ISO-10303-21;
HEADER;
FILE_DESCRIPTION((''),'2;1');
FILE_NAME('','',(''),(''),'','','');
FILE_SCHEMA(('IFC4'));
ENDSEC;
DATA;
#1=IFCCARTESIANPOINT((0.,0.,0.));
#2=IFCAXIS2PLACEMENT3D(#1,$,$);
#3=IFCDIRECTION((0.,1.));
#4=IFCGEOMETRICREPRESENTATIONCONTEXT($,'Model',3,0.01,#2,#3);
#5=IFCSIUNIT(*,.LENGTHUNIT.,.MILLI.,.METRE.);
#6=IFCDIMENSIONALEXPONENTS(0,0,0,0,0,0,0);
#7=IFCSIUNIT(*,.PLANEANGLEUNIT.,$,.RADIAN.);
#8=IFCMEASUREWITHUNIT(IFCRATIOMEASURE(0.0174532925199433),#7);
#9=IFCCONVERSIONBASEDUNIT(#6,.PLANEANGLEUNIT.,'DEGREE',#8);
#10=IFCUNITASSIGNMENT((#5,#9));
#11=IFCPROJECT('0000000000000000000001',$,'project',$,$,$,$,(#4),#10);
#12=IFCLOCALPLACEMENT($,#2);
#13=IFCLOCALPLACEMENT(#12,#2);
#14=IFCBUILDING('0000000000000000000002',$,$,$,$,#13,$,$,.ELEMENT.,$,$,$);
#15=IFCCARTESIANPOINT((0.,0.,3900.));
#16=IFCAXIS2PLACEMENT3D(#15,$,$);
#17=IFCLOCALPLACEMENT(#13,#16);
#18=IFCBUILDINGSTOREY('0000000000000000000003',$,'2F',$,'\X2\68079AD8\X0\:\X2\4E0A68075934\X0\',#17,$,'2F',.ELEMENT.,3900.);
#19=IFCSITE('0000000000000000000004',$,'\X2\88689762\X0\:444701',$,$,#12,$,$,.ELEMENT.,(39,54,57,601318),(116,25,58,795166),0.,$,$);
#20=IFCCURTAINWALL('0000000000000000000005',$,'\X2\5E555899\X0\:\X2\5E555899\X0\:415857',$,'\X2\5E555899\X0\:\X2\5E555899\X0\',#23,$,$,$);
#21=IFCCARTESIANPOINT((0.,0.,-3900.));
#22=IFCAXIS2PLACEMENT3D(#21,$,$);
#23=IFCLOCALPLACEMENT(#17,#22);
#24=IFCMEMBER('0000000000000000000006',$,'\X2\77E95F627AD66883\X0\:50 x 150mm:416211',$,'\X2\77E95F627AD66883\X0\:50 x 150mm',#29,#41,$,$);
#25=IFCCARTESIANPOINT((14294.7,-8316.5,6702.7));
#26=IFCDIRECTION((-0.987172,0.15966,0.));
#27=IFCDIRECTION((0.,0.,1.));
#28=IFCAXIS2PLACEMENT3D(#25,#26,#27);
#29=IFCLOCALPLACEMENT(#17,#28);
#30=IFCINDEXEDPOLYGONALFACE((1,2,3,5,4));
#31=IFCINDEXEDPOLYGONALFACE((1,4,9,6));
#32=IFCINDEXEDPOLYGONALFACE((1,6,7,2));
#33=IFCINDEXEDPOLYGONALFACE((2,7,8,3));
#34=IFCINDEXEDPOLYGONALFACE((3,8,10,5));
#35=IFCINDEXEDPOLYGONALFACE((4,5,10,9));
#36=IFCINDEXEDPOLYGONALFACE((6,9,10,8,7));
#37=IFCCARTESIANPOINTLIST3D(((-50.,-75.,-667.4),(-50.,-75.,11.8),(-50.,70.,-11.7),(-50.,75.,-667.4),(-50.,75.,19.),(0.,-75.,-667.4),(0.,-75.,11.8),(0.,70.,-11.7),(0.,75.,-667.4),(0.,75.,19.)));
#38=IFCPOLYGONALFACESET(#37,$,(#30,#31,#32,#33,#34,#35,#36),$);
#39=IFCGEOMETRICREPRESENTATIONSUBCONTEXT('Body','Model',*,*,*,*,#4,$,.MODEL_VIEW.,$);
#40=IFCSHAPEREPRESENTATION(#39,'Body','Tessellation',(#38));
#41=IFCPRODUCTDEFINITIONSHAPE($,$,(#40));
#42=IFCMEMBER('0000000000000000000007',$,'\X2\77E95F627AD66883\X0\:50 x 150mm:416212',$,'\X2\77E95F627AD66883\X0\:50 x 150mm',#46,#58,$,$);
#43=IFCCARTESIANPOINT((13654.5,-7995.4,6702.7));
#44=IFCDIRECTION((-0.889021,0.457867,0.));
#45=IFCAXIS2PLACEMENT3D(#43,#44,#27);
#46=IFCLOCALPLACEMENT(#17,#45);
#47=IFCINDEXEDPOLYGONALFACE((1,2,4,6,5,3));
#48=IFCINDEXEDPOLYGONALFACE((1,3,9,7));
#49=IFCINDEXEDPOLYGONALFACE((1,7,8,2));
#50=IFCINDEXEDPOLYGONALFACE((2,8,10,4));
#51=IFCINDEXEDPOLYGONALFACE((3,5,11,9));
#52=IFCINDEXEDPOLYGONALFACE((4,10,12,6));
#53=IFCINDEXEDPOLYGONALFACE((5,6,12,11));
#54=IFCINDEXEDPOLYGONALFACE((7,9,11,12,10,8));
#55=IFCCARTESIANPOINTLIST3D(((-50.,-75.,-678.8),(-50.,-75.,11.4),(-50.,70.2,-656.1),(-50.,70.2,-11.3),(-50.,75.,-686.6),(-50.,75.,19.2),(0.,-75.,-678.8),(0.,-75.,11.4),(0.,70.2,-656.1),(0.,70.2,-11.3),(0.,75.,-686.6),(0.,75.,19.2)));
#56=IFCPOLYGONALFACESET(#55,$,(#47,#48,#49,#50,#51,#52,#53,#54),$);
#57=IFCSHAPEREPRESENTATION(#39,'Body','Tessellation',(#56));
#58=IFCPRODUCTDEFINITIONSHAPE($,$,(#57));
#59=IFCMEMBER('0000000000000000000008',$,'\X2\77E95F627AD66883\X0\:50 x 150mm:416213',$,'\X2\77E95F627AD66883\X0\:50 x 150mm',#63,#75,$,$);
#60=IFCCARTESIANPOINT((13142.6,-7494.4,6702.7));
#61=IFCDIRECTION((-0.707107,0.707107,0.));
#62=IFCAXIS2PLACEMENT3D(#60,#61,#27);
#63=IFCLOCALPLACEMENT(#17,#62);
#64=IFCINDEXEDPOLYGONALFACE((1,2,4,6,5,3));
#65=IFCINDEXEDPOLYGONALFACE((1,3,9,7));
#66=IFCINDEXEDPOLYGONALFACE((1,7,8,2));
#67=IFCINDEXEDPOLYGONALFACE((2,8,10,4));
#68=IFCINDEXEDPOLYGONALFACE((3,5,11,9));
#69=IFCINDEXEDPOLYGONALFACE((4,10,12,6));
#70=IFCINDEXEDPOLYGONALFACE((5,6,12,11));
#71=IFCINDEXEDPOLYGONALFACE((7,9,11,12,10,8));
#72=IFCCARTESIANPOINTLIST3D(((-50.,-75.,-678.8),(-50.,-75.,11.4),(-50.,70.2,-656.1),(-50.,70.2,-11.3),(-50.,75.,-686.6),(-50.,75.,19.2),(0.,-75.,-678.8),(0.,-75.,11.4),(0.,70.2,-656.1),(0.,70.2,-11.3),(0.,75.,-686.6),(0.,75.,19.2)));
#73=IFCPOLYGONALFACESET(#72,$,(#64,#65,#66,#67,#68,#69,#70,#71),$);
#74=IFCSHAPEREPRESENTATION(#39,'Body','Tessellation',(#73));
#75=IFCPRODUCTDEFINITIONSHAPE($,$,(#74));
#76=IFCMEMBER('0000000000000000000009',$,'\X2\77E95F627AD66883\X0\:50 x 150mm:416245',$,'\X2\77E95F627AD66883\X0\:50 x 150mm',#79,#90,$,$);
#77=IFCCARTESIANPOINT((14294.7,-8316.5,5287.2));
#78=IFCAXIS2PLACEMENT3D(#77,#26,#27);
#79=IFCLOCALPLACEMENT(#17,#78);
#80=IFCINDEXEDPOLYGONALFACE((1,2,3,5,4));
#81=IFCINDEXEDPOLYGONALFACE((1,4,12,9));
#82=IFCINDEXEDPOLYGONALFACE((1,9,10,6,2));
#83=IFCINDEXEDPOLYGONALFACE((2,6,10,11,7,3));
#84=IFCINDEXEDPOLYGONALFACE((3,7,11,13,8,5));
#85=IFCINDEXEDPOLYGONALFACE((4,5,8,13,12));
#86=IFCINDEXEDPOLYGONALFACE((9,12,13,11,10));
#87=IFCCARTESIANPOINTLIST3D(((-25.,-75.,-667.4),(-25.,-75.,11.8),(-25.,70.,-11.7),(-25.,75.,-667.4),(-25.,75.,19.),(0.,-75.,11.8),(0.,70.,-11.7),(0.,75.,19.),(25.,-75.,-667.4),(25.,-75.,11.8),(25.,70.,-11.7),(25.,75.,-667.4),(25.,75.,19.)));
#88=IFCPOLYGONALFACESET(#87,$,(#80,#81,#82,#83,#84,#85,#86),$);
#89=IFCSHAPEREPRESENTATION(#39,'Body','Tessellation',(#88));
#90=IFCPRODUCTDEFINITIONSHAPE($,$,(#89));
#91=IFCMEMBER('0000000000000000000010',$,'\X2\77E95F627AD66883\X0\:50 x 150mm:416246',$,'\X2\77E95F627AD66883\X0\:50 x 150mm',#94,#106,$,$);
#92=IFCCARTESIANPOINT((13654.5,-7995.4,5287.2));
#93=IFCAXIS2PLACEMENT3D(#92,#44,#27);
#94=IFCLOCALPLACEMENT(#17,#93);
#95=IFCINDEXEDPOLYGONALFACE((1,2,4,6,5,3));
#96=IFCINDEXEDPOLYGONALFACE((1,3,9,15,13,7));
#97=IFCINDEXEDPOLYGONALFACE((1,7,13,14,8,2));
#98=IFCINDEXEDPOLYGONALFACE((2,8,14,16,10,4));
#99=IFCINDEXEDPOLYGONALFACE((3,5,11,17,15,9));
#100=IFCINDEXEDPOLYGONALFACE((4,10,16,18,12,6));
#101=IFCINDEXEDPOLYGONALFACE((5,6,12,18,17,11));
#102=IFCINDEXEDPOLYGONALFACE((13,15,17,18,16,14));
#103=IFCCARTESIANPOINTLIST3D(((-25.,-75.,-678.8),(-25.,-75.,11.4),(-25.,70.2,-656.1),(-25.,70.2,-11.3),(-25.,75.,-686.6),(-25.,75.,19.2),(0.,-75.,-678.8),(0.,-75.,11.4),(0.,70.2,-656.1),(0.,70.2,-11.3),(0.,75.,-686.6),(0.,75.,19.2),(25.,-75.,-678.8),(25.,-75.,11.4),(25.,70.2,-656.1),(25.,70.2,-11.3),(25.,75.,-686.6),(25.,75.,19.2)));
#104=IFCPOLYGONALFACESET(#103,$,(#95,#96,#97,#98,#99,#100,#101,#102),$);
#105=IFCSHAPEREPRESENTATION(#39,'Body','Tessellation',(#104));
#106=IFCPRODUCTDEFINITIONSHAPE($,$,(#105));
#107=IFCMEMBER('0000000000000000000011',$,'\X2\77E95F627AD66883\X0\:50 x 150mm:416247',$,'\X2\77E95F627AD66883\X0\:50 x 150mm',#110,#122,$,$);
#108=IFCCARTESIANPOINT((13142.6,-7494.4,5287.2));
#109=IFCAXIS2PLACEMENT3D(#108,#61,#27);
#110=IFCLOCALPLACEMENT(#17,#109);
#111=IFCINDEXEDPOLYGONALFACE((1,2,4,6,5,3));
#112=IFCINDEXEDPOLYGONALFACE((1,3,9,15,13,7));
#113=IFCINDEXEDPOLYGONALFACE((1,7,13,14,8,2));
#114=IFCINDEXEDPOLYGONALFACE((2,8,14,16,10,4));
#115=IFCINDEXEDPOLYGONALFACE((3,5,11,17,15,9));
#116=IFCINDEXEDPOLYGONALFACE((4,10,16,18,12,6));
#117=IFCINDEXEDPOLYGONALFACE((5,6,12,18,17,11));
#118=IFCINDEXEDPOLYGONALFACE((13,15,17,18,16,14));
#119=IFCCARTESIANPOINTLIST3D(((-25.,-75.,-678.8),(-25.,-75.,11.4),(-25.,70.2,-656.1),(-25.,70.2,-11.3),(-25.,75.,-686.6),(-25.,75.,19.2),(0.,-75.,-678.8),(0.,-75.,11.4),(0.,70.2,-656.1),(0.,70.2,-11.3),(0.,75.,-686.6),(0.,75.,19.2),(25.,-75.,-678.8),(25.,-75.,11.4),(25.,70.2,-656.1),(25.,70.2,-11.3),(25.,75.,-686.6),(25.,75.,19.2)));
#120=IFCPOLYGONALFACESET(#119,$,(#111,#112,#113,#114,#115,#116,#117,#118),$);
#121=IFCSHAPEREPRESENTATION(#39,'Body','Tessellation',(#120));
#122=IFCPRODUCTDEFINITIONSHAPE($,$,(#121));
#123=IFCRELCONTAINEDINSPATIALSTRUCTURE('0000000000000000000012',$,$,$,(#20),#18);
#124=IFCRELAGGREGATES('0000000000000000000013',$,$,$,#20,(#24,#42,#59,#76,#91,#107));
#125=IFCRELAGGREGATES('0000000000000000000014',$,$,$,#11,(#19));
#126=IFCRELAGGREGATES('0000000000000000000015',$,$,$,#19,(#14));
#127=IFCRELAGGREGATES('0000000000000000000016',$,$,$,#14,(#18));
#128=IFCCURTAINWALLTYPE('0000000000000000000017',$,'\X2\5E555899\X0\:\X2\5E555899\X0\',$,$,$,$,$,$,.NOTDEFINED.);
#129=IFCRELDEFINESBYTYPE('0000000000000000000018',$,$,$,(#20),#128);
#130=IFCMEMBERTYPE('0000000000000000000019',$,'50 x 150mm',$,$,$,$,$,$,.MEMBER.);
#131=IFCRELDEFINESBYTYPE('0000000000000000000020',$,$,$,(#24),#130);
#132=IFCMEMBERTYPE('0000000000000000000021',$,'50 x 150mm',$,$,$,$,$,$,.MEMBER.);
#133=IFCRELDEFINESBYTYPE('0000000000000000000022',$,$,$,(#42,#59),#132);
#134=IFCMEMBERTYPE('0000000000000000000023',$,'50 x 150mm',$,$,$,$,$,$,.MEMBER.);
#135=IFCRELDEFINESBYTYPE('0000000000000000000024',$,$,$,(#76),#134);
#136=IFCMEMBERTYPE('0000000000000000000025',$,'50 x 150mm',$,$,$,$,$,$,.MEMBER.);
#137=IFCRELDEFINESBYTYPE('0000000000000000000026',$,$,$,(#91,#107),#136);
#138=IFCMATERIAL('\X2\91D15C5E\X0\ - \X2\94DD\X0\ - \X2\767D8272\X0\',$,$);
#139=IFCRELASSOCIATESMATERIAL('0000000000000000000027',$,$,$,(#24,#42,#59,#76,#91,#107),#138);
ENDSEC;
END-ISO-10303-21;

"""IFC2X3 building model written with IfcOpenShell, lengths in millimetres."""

from ifc_helpers import new_model, entity, si_unit, converted_unit, direction, frame, origin, origin_2d_with_axis, place, context, subcontext, project, spatial, polyline, rectangle, extrude, clip, bounded_halfspace, source, transform, mapped, material, type_object, type_shapes, element, aggregate, save


model = new_model("IFC2X3")

# Units and contexts
model_context = context("Model", 3, precision=0.01, world=origin(), true_north=direction((0.0, 1.0)))
body_context = subcontext(model_context, "Body", "Model", "MODEL_VIEW")
ifc_project = project(units=[si_unit("LENGTHUNIT", "METRE", prefix="MILLI"), converted_unit("PLANEANGLEUNIT", "DEGREE", entity("IfcRatioMeasure", 0.0174532925199433), si_unit("PLANEANGLEUNIT", "RADIAN"), dimensions=[0, 0, 0, 0, 0, 0, 0])], contexts=[model_context])

# Site, building, storey
site_placement = place(None, origin())
site = spatial("IfcSite", under=ifc_project, at=site_placement, Name="表面:444701", CompositionType="ELEMENT", RefLatitude=(39, 54, 57, 601318), RefLongitude=(116, 25, 58, 795166), RefElevation=0.0)
building_placement = place(site_placement, origin())
building = spatial("IfcBuilding", under=site, at=building_placement, CompositionType="ELEMENT")
storey_placement = place(building_placement, frame((0.0, 0.0, 3900.0)))
storey = spatial("IfcBuildingStorey", under=building, at=storey_placement, Name="2F", ObjectType="标高:上标头", LongName="2F", CompositionType="ELEMENT", Elevation=3900.0)

# Curtain wall, member
curtain_wall_type = type_object("IfcCurtainWallType", Name="幕墙:幕墙", PredefinedType="NOTDEFINED")
curtain_wall_1_placement = place(storey_placement, frame((0.0, 0.0, -3900.0)))
curtain_wall_1 = element("IfcCurtainWall", 1, at=curtain_wall_1_placement, inside=storey, type_object=curtain_wall_type, Name="幕墙:幕墙:415857", ObjectType="幕墙:幕墙")
ifc_material_1 = material(Name="金属 - 铝 - 白色")
member_type_1 = type_object("IfcMemberType", Name="50 x 150mm", PredefinedType="MEMBER")
shared_shape_1 = source(origin(), body_context, "Body", "Clipping", [
    clip(clip(extrude(rectangle(XDim=50.0, YDim=150.0, at=origin_2d_with_axis()), frame((-25.0, 0.0, -667.4)), (0.0, 0.0, 1.0), 686.4), bounded_halfspace(frame((-1415.5, 78.0, 37.7), z_axis=(0.0, -0.987172, 0.15966), x_axis=(1.0, 0.0, 0.0)), False, frame((-25.0, 0.0, -667.4)), polyline([(25.0, 75.0), (-25.0, 75.0), (-25.0, 70.0), (25.0, 70.0), (25.0, 75.0)]))), bounded_halfspace(frame((-1415.5, 70.0, -11.7), z_axis=(0.0, 0.15966, 0.987172), x_axis=(1.0, 0.0, 0.0)), False, frame((-25.0, 0.0, -667.4)), polyline([(-25.0, 70.0), (-25.0, -75.0), (25.0, -75.0), (25.0, 70.0), (-25.0, 70.0)]))),
])
type_shapes(member_type_1, [shared_shape_1])
member_1_placement = place(storey_placement, frame((14294.7, -8316.5, 6702.7), z_axis=(-0.987172, 0.15966, 0.0), x_axis=(0.0, 0.0, 1.0)))
member_1 = element("IfcMember", 2, at=member_1_placement, type_object=member_type_1, material=ifc_material_1, Name="矩形竖梃:50 x 150mm:416211", ObjectType="矩形竖梃:50 x 150mm", context=body_context, shape_type="MappedRepresentation", body=[
    mapped(shared_shape_1, transform((0.0, 0.0, 0.0), scale=1.0)),
])

# Members
member_type_2 = type_object("IfcMemberType", Name="50 x 150mm", PredefinedType="MEMBER")
shared_shape_2 = source(origin(), body_context, "Body", "Clipping", [
    clip(clip(clip(clip(extrude(rectangle(XDim=50.0, YDim=150.0, at=origin_2d_with_axis()), frame((-25.0, 0.0, -686.6)), (0.0, 0.0, 1.0), 705.8), bounded_halfspace(frame((-1415.5, -78.0, -679.3), z_axis=(0.0, 0.154283, -0.988027), x_axis=(1.0, 0.0, 0.0)), False, frame((-25.0, 0.0, -686.6)), polyline([(25.0, 70.2), (25.0, -75.0), (-25.0, -75.0), (-25.0, 70.2), (25.0, 70.2)]))), bounded_halfspace(frame((-1415.5, 70.2, -656.1), z_axis=(0.0, -0.988027, -0.154283), x_axis=(1.0, 0.0, 0.0)), False, frame((-25.0, 0.0, -686.6)), polyline([(25.0, 75.0), (25.0, 70.2), (-25.0, 70.2), (-25.0, 75.0), (25.0, 75.0)]))), bounded_halfspace(frame((-1415.5, 78.0, 38.1), z_axis=(0.0, -0.988027, 0.154283), x_axis=(1.0, 0.0, 0.0)), False, frame((-25.0, 0.0, -686.6)), polyline([(25.0, 75.0), (-25.0, 75.0), (-25.0, 70.2), (25.0, 70.2), (25.0, 75.0)]))), bounded_halfspace(frame((-1415.5, 70.2, -11.3), z_axis=(0.0, 0.154283, 0.988027), x_axis=(1.0, 0.0, 0.0)), False, frame((-25.0, 0.0, -686.6)), polyline([(-25.0, 70.2), (-25.0, -75.0), (25.0, -75.0), (25.0, 70.2), (-25.0, 70.2)]))),
])
type_shapes(member_type_2, [shared_shape_2])
member_2_placement = place(storey_placement, frame((13654.5, -7995.4, 6702.7), z_axis=(-0.889021, 0.457867, 0.0), x_axis=(0.0, 0.0, 1.0)))
member_2 = element("IfcMember", 3, at=member_2_placement, type_object=member_type_2, material=ifc_material_1, Name="矩形竖梃:50 x 150mm:416212", ObjectType="矩形竖梃:50 x 150mm", context=body_context, shape_type="MappedRepresentation", body=[
    mapped(shared_shape_2, transform((0.0, 0.0, 0.0), scale=1.0)),
])
member_3_placement = place(storey_placement, frame((13142.6, -7494.4, 6702.7), z_axis=(-0.707107, 0.707107, 0.0), x_axis=(0.0, 0.0, 1.0)))
member_3 = element("IfcMember", 4, at=member_3_placement, type_object=member_type_2, material=ifc_material_1, Name="矩形竖梃:50 x 150mm:416213", ObjectType="矩形竖梃:50 x 150mm", context=body_context, shape_type="MappedRepresentation", body=[
    mapped(shared_shape_2, transform((0.0, 0.0, 0.0), scale=1.0)),
])
member_type_3 = type_object("IfcMemberType", Name="50 x 150mm", PredefinedType="MEMBER")
shared_shape_3 = source(origin(), body_context, "Body", "Clipping", [
    clip(clip(clip(clip(extrude(rectangle(XDim=150.0, YDim=50.0, at=origin_2d_with_axis()), frame((0.0, 0.0, -667.4), z_axis=(0.0, 0.0, 1.0), x_axis=(0.0, -1.0, 0.0)), (0.0, 0.0, 1.0), 686.4), bounded_halfspace(frame((-1390.5, 78.0, 37.7), z_axis=(0.0, -0.987172, 0.15966), x_axis=(1.0, 0.0, 0.0)), False, frame((0.0, 0.0, -667.4), z_axis=(0.0, 0.0, 1.0), x_axis=(0.0, -1.0, 0.0)), polyline([(-75.0, 0.0), (-75.0, -25.0), (-70.0, -25.0), (-70.0, 0.0), (-75.0, 0.0)]))), bounded_halfspace(frame((0.0, 78.0, 37.7), z_axis=(0.0, -0.987172, 0.15966), x_axis=(1.0, 0.0, 0.0)), False, frame((0.0, 0.0, -667.4), z_axis=(0.0, 0.0, 1.0), x_axis=(0.0, -1.0, 0.0)), polyline([(-75.0, 25.0), (-75.0, 0.0), (-70.0, 0.0), (-70.0, 25.0), (-75.0, 25.0)]))), bounded_halfspace(frame((-1390.5, 70.0, -11.7), z_axis=(0.0, 0.15966, 0.987172), x_axis=(1.0, 0.0, 0.0)), False, frame((0.0, 0.0, -667.4), z_axis=(0.0, 0.0, 1.0), x_axis=(0.0, -1.0, 0.0)), polyline([(-70.0, -25.0), (75.0, -25.0), (75.0, 0.0), (-70.0, 0.0), (-70.0, -25.0)]))), bounded_halfspace(frame((0.0, 70.0, -11.7), z_axis=(0.0, 0.15966, 0.987172), x_axis=(1.0, 0.0, 0.0)), False, frame((0.0, 0.0, -667.4), z_axis=(0.0, 0.0, 1.0), x_axis=(0.0, -1.0, 0.0)), polyline([(75.0, 0.0), (75.0, 25.0), (-70.0, 25.0), (-70.0, 0.0), (75.0, 0.0)]))),
])
type_shapes(member_type_3, [shared_shape_3])
member_4_placement = place(storey_placement, frame((14294.7, -8316.5, 5287.2), z_axis=(-0.987172, 0.15966, 0.0), x_axis=(0.0, 0.0, 1.0)))
member_4 = element("IfcMember", 5, at=member_4_placement, type_object=member_type_3, material=ifc_material_1, Name="矩形竖梃:50 x 150mm:416245", ObjectType="矩形竖梃:50 x 150mm", context=body_context, shape_type="MappedRepresentation", body=[
    mapped(shared_shape_3, transform((0.0, 0.0, 0.0), scale=1.0)),
])
member_type_4 = type_object("IfcMemberType", Name="50 x 150mm", PredefinedType="MEMBER")
shared_shape_4 = source(origin(), body_context, "Body", "Clipping", [
    clip(clip(clip(clip(clip(clip(clip(clip(extrude(rectangle(XDim=150.0, YDim=50.0, at=origin_2d_with_axis()), frame((0.0, 0.0, -686.6), z_axis=(0.0, 0.0, 1.0), x_axis=(0.0, -1.0, 0.0)), (0.0, 0.0, 1.0), 705.8), bounded_halfspace(frame((-1390.5, -78.0, -679.3), z_axis=(0.0, 0.154283, -0.988027), x_axis=(1.0, 0.0, 0.0)), False, frame((0.0, 0.0, -686.6), z_axis=(0.0, 0.0, 1.0), x_axis=(0.0, -1.0, 0.0)), polyline([(75.0, 0.0), (75.0, -25.0), (-70.2, -25.0), (-70.2, 0.0), (75.0, 0.0)]))), bounded_halfspace(frame((0.0, -78.0, -679.3), z_axis=(0.0, 0.154283, -0.988027), x_axis=(1.0, 0.0, 0.0)), False, frame((0.0, 0.0, -686.6), z_axis=(0.0, 0.0, 1.0), x_axis=(0.0, -1.0, 0.0)), polyline([(-70.2, 25.0), (75.0, 25.0), (75.0, 0.0), (-70.2, 0.0), (-70.2, 25.0)]))), bounded_halfspace(frame((-1390.5, 70.2, -656.1), z_axis=(0.0, -0.988027, -0.154283), x_axis=(1.0, 0.0, 0.0)), False, frame((0.0, 0.0, -686.6), z_axis=(0.0, 0.0, 1.0), x_axis=(0.0, -1.0, 0.0)), polyline([(-70.2, -25.0), (-75.0, -25.0), (-75.0, 0.0), (-70.2, 0.0), (-70.2, -25.0)]))), bounded_halfspace(frame((0.0, 70.2, -656.1), z_axis=(0.0, -0.988027, -0.154283), x_axis=(1.0, 0.0, 0.0)), False, frame((0.0, 0.0, -686.6), z_axis=(0.0, 0.0, 1.0), x_axis=(0.0, -1.0, 0.0)), polyline([(-75.0, 25.0), (-70.2, 25.0), (-70.2, 0.0), (-75.0, 0.0), (-75.0, 25.0)]))), bounded_halfspace(frame((-1390.5, 78.0, 38.1), z_axis=(0.0, -0.988027, 0.154283), x_axis=(1.0, 0.0, 0.0)), False, frame((0.0, 0.0, -686.6), z_axis=(0.0, 0.0, 1.0), x_axis=(0.0, -1.0, 0.0)), polyline([(-75.0, 0.0), (-75.0, -25.0), (-70.2, -25.0), (-70.2, 0.0), (-75.0, 0.0)]))), bounded_halfspace(frame((0.0, 78.0, 38.1), z_axis=(0.0, -0.988027, 0.154283), x_axis=(1.0, 0.0, 0.0)), False, frame((0.0, 0.0, -686.6), z_axis=(0.0, 0.0, 1.0), x_axis=(0.0, -1.0, 0.0)), polyline([(-75.0, 25.0), (-75.0, 0.0), (-70.2, 0.0), (-70.2, 25.0), (-75.0, 25.0)]))), bounded_halfspace(frame((-1390.5, 70.2, -11.3), z_axis=(0.0, 0.154283, 0.988027), x_axis=(1.0, 0.0, 0.0)), False, frame((0.0, 0.0, -686.6), z_axis=(0.0, 0.0, 1.0), x_axis=(0.0, -1.0, 0.0)), polyline([(-70.2, -25.0), (75.0, -25.0), (75.0, 0.0), (-70.2, 0.0), (-70.2, -25.0)]))), bounded_halfspace(frame((0.0, 70.2, -11.3), z_axis=(0.0, 0.154283, 0.988027), x_axis=(1.0, 0.0, 0.0)), False, frame((0.0, 0.0, -686.6), z_axis=(0.0, 0.0, 1.0), x_axis=(0.0, -1.0, 0.0)), polyline([(75.0, 0.0), (75.0, 25.0), (-70.2, 25.0), (-70.2, 0.0), (75.0, 0.0)]))),
])
type_shapes(member_type_4, [shared_shape_4])
member_5_placement = place(storey_placement, frame((13654.5, -7995.4, 5287.2), z_axis=(-0.889021, 0.457867, 0.0), x_axis=(0.0, 0.0, 1.0)))
member_5 = element("IfcMember", 6, at=member_5_placement, type_object=member_type_4, material=ifc_material_1, Name="矩形竖梃:50 x 150mm:416246", ObjectType="矩形竖梃:50 x 150mm", context=body_context, shape_type="MappedRepresentation", body=[
    mapped(shared_shape_4, transform((0.0, 0.0, 0.0), scale=1.0)),
])
member_6_placement = place(storey_placement, frame((13142.6, -7494.4, 5287.2), z_axis=(-0.707107, 0.707107, 0.0), x_axis=(0.0, 0.0, 1.0)))
member_6 = element("IfcMember", 7, at=member_6_placement, type_object=member_type_4, material=ifc_material_1, Name="矩形竖梃:50 x 150mm:416247", ObjectType="矩形竖梃:50 x 150mm", context=body_context, shape_type="MappedRepresentation", body=[
    mapped(shared_shape_4, transform((0.0, 0.0, 0.0), scale=1.0)),
])

aggregate(curtain_wall_1, [member_1, member_2, member_3, member_4, member_5, member_6])

save(model, "model.ifc")
